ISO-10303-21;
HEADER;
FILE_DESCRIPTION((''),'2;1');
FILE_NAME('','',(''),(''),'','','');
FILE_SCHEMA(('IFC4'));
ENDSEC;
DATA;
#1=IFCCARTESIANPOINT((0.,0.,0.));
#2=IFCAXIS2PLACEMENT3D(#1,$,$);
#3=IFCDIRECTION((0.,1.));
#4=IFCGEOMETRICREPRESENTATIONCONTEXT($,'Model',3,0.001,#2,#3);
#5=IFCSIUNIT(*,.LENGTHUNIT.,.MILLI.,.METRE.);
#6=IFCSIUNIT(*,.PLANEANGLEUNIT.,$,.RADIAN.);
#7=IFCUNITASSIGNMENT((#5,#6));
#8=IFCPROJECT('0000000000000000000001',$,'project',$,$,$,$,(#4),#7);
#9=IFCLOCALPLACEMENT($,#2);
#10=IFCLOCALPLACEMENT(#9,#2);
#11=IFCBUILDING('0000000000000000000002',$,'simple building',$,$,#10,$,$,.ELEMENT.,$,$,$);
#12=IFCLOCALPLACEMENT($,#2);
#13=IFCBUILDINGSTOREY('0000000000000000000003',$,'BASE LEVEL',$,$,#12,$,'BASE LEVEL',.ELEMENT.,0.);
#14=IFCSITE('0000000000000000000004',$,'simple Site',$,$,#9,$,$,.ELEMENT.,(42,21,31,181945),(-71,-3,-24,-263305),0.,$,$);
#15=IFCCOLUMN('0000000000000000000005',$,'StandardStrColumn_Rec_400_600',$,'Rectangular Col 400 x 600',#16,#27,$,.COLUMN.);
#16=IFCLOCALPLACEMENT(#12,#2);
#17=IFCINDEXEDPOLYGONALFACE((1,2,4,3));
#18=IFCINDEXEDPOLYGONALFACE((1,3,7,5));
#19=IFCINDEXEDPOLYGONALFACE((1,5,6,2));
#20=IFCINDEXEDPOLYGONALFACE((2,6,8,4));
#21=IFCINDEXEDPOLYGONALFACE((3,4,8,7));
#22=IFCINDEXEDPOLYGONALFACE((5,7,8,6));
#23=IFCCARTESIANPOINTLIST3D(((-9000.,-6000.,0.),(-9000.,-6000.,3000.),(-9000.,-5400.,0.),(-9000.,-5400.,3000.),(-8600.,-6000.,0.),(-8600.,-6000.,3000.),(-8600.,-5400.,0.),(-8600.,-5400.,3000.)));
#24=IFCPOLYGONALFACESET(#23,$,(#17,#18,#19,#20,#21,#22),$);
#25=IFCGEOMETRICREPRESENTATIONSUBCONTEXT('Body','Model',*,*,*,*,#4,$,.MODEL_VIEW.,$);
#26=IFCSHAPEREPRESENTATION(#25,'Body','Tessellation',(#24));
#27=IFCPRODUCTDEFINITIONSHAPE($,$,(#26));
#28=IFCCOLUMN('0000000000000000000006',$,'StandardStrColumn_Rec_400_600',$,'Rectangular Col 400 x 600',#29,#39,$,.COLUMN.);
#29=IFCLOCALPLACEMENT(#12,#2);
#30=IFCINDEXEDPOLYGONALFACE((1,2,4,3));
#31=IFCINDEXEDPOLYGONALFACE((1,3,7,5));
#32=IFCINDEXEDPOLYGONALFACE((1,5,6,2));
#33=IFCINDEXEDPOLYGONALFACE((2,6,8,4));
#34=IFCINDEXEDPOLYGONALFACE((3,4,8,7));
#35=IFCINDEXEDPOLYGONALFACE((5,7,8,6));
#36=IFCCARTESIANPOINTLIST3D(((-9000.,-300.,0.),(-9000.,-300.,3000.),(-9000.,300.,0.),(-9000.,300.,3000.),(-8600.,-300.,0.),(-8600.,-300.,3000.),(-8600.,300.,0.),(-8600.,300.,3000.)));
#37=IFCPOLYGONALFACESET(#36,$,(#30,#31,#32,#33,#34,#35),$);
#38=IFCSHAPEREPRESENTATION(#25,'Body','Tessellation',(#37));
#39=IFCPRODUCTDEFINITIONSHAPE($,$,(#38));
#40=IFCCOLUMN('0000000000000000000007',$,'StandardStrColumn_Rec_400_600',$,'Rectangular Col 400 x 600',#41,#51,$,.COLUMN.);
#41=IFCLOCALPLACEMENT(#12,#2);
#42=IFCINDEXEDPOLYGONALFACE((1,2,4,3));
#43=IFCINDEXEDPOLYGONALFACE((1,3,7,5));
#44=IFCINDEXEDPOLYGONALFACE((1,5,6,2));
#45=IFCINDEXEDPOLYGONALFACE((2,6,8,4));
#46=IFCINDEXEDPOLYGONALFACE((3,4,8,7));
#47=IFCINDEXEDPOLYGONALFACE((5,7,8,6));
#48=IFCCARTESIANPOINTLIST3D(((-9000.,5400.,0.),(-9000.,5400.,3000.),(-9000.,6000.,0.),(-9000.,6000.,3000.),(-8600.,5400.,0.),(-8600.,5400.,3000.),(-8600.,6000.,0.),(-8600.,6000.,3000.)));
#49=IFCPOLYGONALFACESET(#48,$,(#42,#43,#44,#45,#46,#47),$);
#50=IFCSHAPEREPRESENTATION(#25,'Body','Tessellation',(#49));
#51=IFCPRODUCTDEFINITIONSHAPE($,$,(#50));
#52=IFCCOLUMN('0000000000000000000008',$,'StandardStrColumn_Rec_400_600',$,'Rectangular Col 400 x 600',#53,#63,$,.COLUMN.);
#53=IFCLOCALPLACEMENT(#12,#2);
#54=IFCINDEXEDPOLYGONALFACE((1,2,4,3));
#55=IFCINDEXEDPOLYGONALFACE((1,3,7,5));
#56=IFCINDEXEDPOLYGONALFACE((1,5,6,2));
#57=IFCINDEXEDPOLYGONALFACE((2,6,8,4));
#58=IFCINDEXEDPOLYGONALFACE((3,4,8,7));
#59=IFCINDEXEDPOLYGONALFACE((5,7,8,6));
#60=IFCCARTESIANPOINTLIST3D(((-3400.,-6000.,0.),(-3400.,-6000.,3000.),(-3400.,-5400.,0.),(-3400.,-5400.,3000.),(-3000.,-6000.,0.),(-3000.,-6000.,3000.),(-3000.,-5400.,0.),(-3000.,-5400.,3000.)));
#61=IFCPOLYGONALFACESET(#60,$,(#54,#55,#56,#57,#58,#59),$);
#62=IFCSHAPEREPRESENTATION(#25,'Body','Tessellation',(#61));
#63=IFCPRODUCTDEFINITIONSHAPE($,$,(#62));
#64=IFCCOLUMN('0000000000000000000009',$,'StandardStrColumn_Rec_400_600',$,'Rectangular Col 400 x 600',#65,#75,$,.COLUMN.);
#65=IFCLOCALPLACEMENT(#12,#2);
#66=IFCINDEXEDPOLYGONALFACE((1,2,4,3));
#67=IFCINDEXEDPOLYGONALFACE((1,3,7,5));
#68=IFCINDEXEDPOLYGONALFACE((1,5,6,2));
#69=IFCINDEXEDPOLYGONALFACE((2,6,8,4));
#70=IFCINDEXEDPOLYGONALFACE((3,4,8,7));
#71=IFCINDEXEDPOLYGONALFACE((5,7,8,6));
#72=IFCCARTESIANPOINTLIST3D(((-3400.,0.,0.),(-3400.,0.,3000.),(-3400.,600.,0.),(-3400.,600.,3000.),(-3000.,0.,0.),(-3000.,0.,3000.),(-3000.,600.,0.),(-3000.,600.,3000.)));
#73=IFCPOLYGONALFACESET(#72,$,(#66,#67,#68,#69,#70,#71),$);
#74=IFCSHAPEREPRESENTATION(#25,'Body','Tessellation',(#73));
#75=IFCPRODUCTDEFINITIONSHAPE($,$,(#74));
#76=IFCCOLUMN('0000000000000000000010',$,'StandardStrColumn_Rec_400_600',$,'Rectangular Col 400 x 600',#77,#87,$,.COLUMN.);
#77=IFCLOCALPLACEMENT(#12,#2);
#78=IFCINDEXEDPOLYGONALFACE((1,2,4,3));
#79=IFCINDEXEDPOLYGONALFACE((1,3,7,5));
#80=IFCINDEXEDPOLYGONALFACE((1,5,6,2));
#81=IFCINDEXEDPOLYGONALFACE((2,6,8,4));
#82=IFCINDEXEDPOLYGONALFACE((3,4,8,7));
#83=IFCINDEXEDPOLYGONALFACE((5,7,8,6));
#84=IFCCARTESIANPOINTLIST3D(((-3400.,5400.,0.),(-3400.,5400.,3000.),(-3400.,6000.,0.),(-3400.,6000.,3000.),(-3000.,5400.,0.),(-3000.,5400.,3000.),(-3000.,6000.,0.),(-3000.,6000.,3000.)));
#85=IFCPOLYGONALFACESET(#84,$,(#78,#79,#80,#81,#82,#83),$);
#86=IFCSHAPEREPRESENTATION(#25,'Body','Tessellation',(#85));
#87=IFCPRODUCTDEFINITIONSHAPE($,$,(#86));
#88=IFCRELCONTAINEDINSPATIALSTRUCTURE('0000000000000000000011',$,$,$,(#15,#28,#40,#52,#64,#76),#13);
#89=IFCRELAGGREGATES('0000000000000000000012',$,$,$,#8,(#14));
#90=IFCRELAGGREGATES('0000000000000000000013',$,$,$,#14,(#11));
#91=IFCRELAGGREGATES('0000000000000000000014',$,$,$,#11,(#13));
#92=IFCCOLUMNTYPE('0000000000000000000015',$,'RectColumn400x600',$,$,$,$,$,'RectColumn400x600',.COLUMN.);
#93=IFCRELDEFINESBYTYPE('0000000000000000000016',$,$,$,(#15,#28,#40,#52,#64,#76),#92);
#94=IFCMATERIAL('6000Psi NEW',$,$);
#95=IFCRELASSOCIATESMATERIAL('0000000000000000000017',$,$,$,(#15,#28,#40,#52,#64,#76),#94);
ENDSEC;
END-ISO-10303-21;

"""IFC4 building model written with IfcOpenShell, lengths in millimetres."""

from ifc_helpers import new_model, si_unit, direction, frame, origin, origin_with_axes, origin_2d_with_axis, place, context, subcontext, project, spatial, rectangle, extrude, material, material_profile, profile_set, profile_usage, type_object, element, save


model = new_model("IFC4")

# Units and contexts
model_context = context("Model", 3, precision=0.001, world=origin(), true_north=direction((0.0, 1.0)))
body_context = subcontext(model_context, "Body", "Model", "MODEL_VIEW")
ifc_project = project(units=[si_unit("LENGTHUNIT", "METRE", prefix="MILLI"), si_unit("PLANEANGLEUNIT", "RADIAN")], contexts=[model_context])

# Site, building, storey
site_placement = place(None, origin())
site = spatial("IfcSite", under=ifc_project, at=site_placement, Name="simple Site", CompositionType="ELEMENT", RefLatitude=(42, 21, 31, 181945), RefLongitude=(-71, -3, -24, -263305), RefElevation=0.0)
building_placement = place(site_placement, origin())
building = spatial("IfcBuilding", under=site, at=building_placement, Name="simple building", CompositionType="ELEMENT")
storey_placement = place(None, origin())
storey = spatial("IfcBuildingStorey", under=building, at=storey_placement, Name="BASE LEVEL", LongName="BASE LEVEL", CompositionType="ELEMENT", Elevation=0.0)

# Columns
ifc_material = material(Name="6000Psi NEW")
ifc_material_profile = material_profile(ifc_material, rectangle(XDim=400.0, YDim=600.0, at=origin_2d_with_axis()))
ifc_profile_set = profile_set([ifc_material_profile])
ifc_profile_usage_1 = profile_usage(ifc_profile_set, cardinal=7)
column_type = type_object("IfcColumnType", Name="RectColumn400x600", ElementType="RectColumn400x600", PredefinedType="COLUMN")
column_1_placement = place(None, frame((-8800.0, -5700.0, 0.0), z_axis=(0.0, 0.0, 1.0), x_axis=(1.0, 0.0, 0.0)))
element("IfcColumn", 1, at=column_1_placement, inside=storey, type_object=column_type, material=ifc_profile_usage_1, Name="StandardStrColumn_Rec_400_600", ObjectType="Rectangular Col 400 x 600", PredefinedType="COLUMN", context=body_context, shape_type="SweptSolid", body=[
    extrude(rectangle(XDim=400.0, YDim=600.0, at=origin_2d_with_axis()), origin_with_axes(), (0.0, 0.0, 1.0), 3000.0),
])
ifc_profile_usage_2 = profile_usage(ifc_profile_set, cardinal=4)
column_2_placement = place(None, frame((-8800.0, 0.0, 0.0), z_axis=(0.0, 0.0, 1.0), x_axis=(1.0, 0.0, 0.0)))
element("IfcColumn", 2, at=column_2_placement, inside=storey, type_object=column_type, material=ifc_profile_usage_2, Name="StandardStrColumn_Rec_400_600", ObjectType="Rectangular Col 400 x 600", PredefinedType="COLUMN", context=body_context, shape_type="SweptSolid", body=[
    extrude(rectangle(XDim=400.0, YDim=600.0, at=origin_2d_with_axis()), origin_with_axes(), (0.0, 0.0, 1.0), 3000.0),
])
ifc_profile_usage_3 = profile_usage(ifc_profile_set, cardinal=1)
column_3_placement = place(None, frame((-8800.0, 5700.0, 0.0), z_axis=(0.0, 0.0, 1.0), x_axis=(1.0, 0.0, 0.0)))
element("IfcColumn", 3, at=column_3_placement, inside=storey, type_object=column_type, material=ifc_profile_usage_3, Name="StandardStrColumn_Rec_400_600", ObjectType="Rectangular Col 400 x 600", PredefinedType="COLUMN", context=body_context, shape_type="SweptSolid", body=[
    extrude(rectangle(XDim=400.0, YDim=600.0, at=origin_2d_with_axis()), origin_with_axes(), (0.0, 0.0, 1.0), 3000.0),
])
ifc_profile_usage_4 = profile_usage(ifc_profile_set, cardinal=9)
for number, where, z_axis, x_axis, name in (
    (4, (-3200.0, -5700.0, 0.0), (0.0, 0.0, 1.0), (1.0, 0.0, 0.0), "StandardStrColumn_Rec_400_600"),
    (5, (-3200.0, 300.0, 0.0), (0.0, 0.0, 1.0), (1.0, 0.0, 0.0), "StandardStrColumn_Rec_400_600"),
):
    element("IfcColumn", number, at=place(None, frame(where, z_axis=z_axis, x_axis=x_axis)), inside=storey, type_object=column_type, material=ifc_profile_usage_4, Name=name, ObjectType="Rectangular Col 400 x 600", PredefinedType="COLUMN", context=body_context, shape_type="SweptSolid", body=[
        extrude(rectangle(XDim=400.0, YDim=600.0, at=origin_2d_with_axis()), origin_with_axes(), (0.0, 0.0, 1.0), 3000.0),
    ])
ifc_profile_usage_5 = profile_usage(ifc_profile_set, cardinal=3)
column_4_placement = place(None, frame((-3200.0, 5700.0, 0.0), z_axis=(0.0, 0.0, 1.0), x_axis=(1.0, 0.0, 0.0)))
element("IfcColumn", 6, at=column_4_placement, inside=storey, type_object=column_type, material=ifc_profile_usage_5, Name="StandardStrColumn_Rec_400_600", ObjectType="Rectangular Col 400 x 600", PredefinedType="COLUMN", context=body_context, shape_type="SweptSolid", body=[
    extrude(rectangle(XDim=400.0, YDim=600.0, at=origin_2d_with_axis()), origin_with_axes(), (0.0, 0.0, 1.0), 3000.0),
])

save(model, "model.ifc")
